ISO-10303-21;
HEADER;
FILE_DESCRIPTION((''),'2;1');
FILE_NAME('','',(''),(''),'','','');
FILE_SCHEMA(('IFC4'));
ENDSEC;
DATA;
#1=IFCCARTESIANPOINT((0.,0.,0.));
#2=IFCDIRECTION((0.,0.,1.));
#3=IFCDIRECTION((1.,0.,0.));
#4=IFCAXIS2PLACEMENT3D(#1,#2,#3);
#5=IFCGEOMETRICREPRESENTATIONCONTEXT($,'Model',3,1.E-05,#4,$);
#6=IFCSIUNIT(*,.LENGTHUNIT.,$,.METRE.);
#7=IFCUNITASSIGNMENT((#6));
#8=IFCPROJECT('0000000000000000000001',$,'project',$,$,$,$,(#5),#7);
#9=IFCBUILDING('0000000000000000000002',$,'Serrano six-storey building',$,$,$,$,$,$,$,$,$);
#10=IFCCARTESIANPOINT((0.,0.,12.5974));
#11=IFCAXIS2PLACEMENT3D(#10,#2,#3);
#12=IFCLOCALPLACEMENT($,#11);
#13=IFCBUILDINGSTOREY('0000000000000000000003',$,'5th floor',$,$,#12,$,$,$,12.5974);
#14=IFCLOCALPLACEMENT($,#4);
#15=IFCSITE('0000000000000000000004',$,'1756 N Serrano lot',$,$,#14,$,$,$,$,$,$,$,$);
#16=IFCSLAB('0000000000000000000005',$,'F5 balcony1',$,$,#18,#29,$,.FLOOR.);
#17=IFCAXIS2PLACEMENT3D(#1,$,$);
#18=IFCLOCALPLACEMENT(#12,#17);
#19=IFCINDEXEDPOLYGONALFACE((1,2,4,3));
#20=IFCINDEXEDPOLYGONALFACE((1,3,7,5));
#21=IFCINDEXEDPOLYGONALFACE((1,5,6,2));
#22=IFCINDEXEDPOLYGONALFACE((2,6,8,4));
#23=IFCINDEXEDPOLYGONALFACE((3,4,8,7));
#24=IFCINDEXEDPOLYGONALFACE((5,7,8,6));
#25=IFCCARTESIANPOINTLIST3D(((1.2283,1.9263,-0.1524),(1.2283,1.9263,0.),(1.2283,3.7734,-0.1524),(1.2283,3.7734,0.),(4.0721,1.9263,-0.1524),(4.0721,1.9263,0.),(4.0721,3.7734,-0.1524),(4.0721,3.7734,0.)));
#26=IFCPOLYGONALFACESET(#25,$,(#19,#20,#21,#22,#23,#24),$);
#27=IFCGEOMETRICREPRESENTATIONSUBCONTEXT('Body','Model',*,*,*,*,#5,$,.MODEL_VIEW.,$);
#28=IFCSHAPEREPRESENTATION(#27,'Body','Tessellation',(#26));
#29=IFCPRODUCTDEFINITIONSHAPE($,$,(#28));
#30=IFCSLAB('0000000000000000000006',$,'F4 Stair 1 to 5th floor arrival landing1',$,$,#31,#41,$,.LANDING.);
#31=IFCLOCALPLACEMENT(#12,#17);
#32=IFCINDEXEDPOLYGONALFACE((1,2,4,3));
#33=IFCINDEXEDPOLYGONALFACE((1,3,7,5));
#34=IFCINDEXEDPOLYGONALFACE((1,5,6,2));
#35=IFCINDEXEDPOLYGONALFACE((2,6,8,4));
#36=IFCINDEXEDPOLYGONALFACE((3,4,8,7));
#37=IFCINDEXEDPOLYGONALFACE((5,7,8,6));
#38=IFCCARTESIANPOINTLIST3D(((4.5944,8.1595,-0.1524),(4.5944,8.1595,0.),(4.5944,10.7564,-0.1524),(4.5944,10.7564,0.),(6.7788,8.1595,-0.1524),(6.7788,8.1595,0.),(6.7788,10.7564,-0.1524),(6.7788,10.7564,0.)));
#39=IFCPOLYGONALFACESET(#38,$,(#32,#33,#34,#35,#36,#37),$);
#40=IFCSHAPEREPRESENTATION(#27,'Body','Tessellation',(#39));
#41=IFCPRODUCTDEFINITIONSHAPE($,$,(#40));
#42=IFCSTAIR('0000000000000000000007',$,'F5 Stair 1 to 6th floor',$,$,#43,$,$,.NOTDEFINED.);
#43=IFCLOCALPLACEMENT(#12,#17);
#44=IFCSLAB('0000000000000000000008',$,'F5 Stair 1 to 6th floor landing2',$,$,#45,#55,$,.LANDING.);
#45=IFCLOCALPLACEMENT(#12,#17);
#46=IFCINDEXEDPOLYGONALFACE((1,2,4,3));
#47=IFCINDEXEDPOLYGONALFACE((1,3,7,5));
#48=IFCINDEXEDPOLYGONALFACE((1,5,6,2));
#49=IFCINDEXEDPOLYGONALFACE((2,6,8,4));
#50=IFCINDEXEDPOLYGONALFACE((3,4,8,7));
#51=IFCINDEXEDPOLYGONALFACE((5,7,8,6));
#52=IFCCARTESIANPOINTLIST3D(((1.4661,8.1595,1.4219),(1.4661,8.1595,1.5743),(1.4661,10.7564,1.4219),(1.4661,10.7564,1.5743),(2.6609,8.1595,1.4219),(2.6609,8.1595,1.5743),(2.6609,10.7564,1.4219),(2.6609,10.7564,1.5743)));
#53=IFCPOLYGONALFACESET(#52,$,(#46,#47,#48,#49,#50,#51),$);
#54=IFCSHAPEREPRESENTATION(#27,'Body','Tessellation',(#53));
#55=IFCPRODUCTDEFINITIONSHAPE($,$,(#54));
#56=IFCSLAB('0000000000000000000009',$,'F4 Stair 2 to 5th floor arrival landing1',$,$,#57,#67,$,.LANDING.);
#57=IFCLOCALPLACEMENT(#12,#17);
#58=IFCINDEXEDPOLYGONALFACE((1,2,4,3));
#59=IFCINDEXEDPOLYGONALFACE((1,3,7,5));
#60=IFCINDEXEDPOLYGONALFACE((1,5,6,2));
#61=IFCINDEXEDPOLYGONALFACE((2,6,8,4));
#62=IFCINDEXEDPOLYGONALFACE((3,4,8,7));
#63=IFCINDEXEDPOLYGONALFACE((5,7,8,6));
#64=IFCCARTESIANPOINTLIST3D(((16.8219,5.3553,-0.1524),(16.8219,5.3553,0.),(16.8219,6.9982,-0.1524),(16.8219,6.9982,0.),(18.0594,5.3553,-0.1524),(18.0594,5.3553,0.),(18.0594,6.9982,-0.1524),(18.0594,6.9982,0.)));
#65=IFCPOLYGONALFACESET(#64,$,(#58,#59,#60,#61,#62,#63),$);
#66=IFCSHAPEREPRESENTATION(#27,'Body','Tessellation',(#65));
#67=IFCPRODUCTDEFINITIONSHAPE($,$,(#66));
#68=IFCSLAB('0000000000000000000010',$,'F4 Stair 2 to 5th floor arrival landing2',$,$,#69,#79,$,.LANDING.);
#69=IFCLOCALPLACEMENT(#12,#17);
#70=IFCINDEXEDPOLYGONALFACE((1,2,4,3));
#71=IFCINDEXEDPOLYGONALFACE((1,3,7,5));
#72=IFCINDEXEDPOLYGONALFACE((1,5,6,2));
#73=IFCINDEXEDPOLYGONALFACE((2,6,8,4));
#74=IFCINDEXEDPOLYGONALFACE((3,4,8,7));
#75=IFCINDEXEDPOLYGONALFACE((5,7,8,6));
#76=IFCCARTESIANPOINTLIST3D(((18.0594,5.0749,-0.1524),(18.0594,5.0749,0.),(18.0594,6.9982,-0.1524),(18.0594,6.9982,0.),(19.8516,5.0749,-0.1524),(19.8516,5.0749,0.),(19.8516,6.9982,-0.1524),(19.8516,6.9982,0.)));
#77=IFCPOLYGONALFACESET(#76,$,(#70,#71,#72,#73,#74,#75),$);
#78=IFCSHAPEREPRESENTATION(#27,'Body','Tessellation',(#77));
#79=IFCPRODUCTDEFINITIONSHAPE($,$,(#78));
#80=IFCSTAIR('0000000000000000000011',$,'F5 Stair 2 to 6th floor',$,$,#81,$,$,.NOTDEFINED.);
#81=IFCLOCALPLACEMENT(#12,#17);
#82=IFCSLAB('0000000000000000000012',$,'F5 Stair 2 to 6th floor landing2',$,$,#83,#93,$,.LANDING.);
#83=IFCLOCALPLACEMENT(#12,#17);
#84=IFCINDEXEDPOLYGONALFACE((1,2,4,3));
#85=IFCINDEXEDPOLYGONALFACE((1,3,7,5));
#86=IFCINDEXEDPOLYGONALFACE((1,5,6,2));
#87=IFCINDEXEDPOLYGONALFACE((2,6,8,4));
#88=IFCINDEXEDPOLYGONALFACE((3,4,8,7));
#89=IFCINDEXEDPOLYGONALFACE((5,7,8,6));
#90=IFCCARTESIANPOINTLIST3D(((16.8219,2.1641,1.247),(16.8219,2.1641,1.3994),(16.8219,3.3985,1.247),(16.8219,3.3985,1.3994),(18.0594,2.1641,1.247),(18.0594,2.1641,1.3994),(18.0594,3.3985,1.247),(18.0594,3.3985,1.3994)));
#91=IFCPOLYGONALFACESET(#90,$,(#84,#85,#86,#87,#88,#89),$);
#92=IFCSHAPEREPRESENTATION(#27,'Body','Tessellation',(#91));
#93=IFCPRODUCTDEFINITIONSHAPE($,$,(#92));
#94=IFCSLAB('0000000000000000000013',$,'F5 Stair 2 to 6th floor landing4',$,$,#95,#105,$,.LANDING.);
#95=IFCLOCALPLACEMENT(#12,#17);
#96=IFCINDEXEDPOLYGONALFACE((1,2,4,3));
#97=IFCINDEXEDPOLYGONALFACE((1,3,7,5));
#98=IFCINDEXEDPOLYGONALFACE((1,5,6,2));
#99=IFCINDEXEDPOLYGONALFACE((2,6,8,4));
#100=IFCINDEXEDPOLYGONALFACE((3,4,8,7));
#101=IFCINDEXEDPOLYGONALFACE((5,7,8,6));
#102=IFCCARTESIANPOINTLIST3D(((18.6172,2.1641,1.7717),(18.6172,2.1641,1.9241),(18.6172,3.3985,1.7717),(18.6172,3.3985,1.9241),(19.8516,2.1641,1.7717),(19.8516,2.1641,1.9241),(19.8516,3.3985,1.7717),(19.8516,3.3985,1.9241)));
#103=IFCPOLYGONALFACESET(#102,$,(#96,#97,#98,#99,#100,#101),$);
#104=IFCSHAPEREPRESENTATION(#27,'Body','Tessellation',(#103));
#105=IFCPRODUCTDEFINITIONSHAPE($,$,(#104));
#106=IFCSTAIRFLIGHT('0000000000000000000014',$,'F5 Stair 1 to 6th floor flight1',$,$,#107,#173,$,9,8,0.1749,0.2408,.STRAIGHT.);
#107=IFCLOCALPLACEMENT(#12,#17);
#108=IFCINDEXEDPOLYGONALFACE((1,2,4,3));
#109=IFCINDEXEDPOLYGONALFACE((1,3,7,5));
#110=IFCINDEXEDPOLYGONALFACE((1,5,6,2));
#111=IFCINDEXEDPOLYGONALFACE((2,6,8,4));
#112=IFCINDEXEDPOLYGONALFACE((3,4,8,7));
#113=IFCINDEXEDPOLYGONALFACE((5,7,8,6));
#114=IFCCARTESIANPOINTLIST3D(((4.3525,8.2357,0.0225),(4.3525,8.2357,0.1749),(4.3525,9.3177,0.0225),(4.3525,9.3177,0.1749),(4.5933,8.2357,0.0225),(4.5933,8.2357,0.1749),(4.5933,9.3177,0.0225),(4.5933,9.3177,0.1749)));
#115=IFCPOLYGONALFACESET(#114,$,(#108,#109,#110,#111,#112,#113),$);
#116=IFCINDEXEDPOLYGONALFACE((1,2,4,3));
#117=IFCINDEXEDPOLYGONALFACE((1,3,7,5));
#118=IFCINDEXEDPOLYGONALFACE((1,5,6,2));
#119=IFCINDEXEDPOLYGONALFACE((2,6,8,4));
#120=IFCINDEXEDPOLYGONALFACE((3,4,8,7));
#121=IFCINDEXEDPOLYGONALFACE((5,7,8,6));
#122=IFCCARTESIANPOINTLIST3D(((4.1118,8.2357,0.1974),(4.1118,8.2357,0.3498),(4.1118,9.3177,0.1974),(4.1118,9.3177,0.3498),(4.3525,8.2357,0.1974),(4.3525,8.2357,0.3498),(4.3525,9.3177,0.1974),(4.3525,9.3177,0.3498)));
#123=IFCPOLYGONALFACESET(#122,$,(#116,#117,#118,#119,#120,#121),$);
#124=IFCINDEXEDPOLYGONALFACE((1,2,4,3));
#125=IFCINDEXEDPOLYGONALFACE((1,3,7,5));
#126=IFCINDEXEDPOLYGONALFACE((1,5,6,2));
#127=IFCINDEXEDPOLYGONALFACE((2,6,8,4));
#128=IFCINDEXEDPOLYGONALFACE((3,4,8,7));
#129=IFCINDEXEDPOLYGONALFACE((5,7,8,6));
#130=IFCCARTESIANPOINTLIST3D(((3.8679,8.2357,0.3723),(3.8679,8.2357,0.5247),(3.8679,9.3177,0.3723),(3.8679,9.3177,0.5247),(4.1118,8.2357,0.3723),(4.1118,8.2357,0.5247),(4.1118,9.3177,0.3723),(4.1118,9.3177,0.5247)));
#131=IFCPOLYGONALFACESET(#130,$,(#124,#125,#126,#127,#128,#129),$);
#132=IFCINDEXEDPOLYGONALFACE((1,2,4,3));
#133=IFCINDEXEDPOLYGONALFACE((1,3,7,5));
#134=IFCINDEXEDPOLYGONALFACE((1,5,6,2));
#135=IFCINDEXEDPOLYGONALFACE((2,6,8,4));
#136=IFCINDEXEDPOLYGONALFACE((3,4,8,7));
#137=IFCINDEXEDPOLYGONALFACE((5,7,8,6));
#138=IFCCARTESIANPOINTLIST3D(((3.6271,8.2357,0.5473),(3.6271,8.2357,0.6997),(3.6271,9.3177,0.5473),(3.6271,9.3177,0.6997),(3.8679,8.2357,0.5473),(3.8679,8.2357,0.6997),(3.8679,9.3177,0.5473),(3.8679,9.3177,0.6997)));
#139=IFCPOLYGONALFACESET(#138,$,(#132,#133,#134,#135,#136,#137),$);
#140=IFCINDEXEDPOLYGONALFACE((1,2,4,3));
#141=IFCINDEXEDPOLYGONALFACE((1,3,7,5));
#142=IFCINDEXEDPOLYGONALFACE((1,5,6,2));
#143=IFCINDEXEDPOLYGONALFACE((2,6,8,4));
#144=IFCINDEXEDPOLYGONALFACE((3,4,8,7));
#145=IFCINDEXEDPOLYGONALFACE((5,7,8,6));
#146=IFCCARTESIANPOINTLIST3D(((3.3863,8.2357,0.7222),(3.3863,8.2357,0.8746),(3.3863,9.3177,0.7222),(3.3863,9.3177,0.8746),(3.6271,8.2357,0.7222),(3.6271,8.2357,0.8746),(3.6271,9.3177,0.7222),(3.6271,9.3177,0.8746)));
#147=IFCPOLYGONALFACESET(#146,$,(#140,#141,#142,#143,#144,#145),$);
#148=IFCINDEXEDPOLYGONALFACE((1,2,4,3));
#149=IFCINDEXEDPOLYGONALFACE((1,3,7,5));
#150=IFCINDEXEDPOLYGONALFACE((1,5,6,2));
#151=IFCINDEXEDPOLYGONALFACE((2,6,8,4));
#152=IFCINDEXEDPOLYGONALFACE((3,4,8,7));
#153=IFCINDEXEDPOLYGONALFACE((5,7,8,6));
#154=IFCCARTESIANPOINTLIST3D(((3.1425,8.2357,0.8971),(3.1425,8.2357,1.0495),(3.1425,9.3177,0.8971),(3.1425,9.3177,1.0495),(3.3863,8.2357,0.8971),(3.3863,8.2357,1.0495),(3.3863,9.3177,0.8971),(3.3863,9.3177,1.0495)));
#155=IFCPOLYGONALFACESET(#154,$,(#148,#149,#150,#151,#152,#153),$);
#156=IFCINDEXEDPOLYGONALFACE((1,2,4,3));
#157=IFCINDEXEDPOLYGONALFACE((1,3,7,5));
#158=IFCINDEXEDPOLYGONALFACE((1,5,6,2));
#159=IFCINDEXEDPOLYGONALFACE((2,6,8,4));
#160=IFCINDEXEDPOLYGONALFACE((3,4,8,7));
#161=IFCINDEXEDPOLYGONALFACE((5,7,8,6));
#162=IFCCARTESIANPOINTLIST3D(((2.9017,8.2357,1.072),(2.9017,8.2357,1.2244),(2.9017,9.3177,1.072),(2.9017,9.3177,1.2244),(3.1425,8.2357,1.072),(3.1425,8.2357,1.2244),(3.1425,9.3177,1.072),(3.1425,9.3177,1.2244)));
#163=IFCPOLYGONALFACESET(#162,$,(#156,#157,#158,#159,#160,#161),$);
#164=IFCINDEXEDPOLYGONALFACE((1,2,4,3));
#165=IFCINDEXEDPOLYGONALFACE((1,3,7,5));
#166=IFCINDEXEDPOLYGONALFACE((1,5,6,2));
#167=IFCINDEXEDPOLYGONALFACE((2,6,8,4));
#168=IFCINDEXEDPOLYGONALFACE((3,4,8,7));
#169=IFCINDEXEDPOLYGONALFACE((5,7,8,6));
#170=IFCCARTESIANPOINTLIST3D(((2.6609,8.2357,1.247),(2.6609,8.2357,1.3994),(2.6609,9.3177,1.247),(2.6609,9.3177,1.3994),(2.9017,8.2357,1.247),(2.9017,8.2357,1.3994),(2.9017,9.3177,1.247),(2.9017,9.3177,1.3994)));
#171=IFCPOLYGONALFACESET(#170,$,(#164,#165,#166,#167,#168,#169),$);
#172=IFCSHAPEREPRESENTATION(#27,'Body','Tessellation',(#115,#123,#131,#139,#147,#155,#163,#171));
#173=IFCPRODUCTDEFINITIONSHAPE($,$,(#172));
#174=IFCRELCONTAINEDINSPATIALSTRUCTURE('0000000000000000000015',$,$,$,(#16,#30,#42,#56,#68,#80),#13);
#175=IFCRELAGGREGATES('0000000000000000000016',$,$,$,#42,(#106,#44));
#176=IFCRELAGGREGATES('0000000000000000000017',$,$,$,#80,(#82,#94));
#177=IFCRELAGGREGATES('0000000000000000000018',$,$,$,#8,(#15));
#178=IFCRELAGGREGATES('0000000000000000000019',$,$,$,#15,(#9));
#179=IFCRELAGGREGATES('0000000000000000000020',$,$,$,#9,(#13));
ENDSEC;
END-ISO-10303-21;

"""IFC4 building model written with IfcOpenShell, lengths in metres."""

from ifc_helpers import new_model, si_unit, frame, origin_with_axes, place, context, subcontext, project, spatial, polyline, outline, extrude, element, aggregate, save


model = new_model("IFC4")

# Units and contexts
model_context = context("Model", 3, precision=1e-05, world=origin_with_axes())
body_context = subcontext(model_context, "Body", "Model", "MODEL_VIEW")
ifc_project = project(units=[si_unit("LENGTHUNIT", "METRE")], contexts=[model_context])

# Site, building, storey
site_placement = place(None, origin_with_axes())
site = spatial("IfcSite", under=ifc_project, at=site_placement, Name="1756 N Serrano lot")
building = spatial("IfcBuilding", under=site, Name="Serrano six-storey building")
storey_placement = place(None, frame((0.0, 0.0, 12.5974), z_axis=(0.0, 0.0, 1.0), x_axis=(1.0, 0.0, 0.0)))
storey = spatial("IfcBuildingStorey", under=building, at=storey_placement, Name="5th floor", Elevation=12.5974)

# Slabs
slab_1_placement = place(storey_placement, frame((0.0, 0.0, -12.5974), z_axis=(0.0, 0.0, 1.0), x_axis=(1.0, 0.0, 0.0)))
element("IfcSlab", 1, at=slab_1_placement, inside=storey, Name="F5 balcony1", PredefinedType="FLOOR", context=body_context, shape_type="SweptSolid", body=[
    extrude(outline(polyline([(4.0721, 1.9263), (4.0721, 3.7734), (1.2283, 3.7734), (1.2283, 1.9263), (4.0721, 1.9263)])), frame((0.0, 0.0, 12.445)), (0.0, 0.0, 1.0), 0.1524),
])
slab_2_placement = place(storey_placement, frame((0.0, 0.0, -12.5974), z_axis=(0.0, 0.0, 1.0), x_axis=(1.0, 0.0, 0.0)))
element("IfcSlab", 2, at=slab_2_placement, inside=storey, Name="F4 Stair 1 to 5th floor arrival landing1", PredefinedType="LANDING", context=body_context, shape_type="SweptSolid", body=[
    extrude(outline(polyline([(6.7788, 8.1595), (6.7788, 10.7564), (4.5944, 10.7564), (4.5944, 8.1595), (6.7788, 8.1595)])), frame((0.0, 0.0, 12.445)), (0.0, 0.0, 1.0), 0.1524),
])

# Stair, slab
stair_1 = element("IfcStair", 3, inside=storey, Name="F5 Stair 1 to 6th floor", PredefinedType="NOTDEFINED")
slab_3_placement = place(None, origin_with_axes())
slab_3 = element("IfcSlab", 4, at=slab_3_placement, Name="F5 Stair 1 to 6th floor landing2", PredefinedType="LANDING", context=body_context, shape_type="SweptSolid", body=[
    extrude(outline(polyline([(2.6609, 8.1595), (2.6609, 10.7564), (1.4661, 10.7564), (1.4661, 8.1595), (2.6609, 8.1595)])), frame((0.0, 0.0, 14.0193)), (0.0, 0.0, 1.0), 0.1524),
])

# Slabs
slab_4_placement = place(storey_placement, frame((0.0, 0.0, -12.5974), z_axis=(0.0, 0.0, 1.0), x_axis=(1.0, 0.0, 0.0)))
element("IfcSlab", 5, at=slab_4_placement, inside=storey, Name="F4 Stair 2 to 5th floor arrival landing1", PredefinedType="LANDING", context=body_context, shape_type="SweptSolid", body=[
    extrude(outline(polyline([(18.0594, 5.3553), (18.0594, 6.9982), (16.8219, 6.9982), (16.8219, 5.3553), (18.0594, 5.3553)])), frame((0.0, 0.0, 12.445)), (0.0, 0.0, 1.0), 0.1524),
])
slab_5_placement = place(storey_placement, frame((0.0, 0.0, -12.5974), z_axis=(0.0, 0.0, 1.0), x_axis=(1.0, 0.0, 0.0)))
element("IfcSlab", 6, at=slab_5_placement, inside=storey, Name="F4 Stair 2 to 5th floor arrival landing2", PredefinedType="LANDING", context=body_context, shape_type="SweptSolid", body=[
    extrude(outline(polyline([(19.8516, 5.0749), (19.8516, 6.9982), (18.0594, 6.9982), (18.0594, 5.0749), (19.8516, 5.0749)])), frame((0.0, 0.0, 12.445)), (0.0, 0.0, 1.0), 0.1524),
])

# Stair, slabs
stair_2 = element("IfcStair", 7, inside=storey, Name="F5 Stair 2 to 6th floor", PredefinedType="NOTDEFINED")
slab_6_placement = place(None, origin_with_axes())
slab_6 = element("IfcSlab", 8, at=slab_6_placement, Name="F5 Stair 2 to 6th floor landing2", PredefinedType="LANDING", context=body_context, shape_type="SweptSolid", body=[
    extrude(outline(polyline([(18.0594, 2.1641), (18.0594, 3.3985), (16.8219, 3.3985), (16.8219, 2.1641), (18.0594, 2.1641)])), frame((0.0, 0.0, 13.8444)), (0.0, 0.0, 1.0), 0.1524),
])
slab_7_placement = place(None, origin_with_axes())
slab_7 = element("IfcSlab", 9, at=slab_7_placement, Name="F5 Stair 2 to 6th floor landing4", PredefinedType="LANDING", context=body_context, shape_type="SweptSolid", body=[
    extrude(outline(polyline([(19.8516, 2.1641), (19.8516, 3.3985), (18.6172, 3.3985), (18.6172, 2.1641), (19.8516, 2.1641)])), frame((0.0, 0.0, 14.3691)), (0.0, 0.0, 1.0), 0.1524),
])

# Stair flight
stair_flight_1_placement = place(None, origin_with_axes())
stair_flight_1 = element("IfcStairFlight", 10, at=stair_flight_1_placement, Name="F5 Stair 1 to 6th floor flight1", NumberOfRisers=9, NumberOfTreads=8, PredefinedType="STRAIGHT", RiserHeight=0.1749, TreadLength=0.2408, context=body_context, shape_type="SweptSolid", body=[
    extrude(outline(polyline([(4.5933, 8.2357), (4.5933, 9.3177), (4.3525, 9.3177), (4.3525, 8.2357), (4.5933, 8.2357)])), frame((0.0, 0.0, 12.6199)), (0.0, 0.0, 1.0), 0.1524),
    extrude(outline(polyline([(4.3525, 8.2357), (4.3525, 9.3177), (4.1118, 9.3177), (4.1118, 8.2357), (4.3525, 8.2357)])), frame((0.0, 0.0, 12.7948)), (0.0, 0.0, 1.0), 0.1524),
    extrude(outline(polyline([(4.1118, 8.2357), (4.1118, 9.3177), (3.8679, 9.3177), (3.8679, 8.2357), (4.1118, 8.2357)])), frame((0.0, 0.0, 12.9697)), (0.0, 0.0, 1.0), 0.1524),
    extrude(outline(polyline([(3.8679, 8.2357), (3.8679, 9.3177), (3.6271, 9.3177), (3.6271, 8.2357), (3.8679, 8.2357)])), frame((0.0, 0.0, 13.1447)), (0.0, 0.0, 1.0), 0.1524),
    extrude(outline(polyline([(3.6271, 8.2357), (3.6271, 9.3177), (3.3863, 9.3177), (3.3863, 8.2357), (3.6271, 8.2357)])), frame((0.0, 0.0, 13.3196)), (0.0, 0.0, 1.0), 0.1524),
    extrude(outline(polyline([(3.3863, 8.2357), (3.3863, 9.3177), (3.1425, 9.3177), (3.1425, 8.2357), (3.3863, 8.2357)])), frame((0.0, 0.0, 13.4945)), (0.0, 0.0, 1.0), 0.1524),
    extrude(outline(polyline([(3.1425, 8.2357), (3.1425, 9.3177), (2.9017, 9.3177), (2.9017, 8.2357), (3.1425, 8.2357)])), frame((0.0, 0.0, 13.6694)), (0.0, 0.0, 1.0), 0.1524),
    extrude(outline(polyline([(2.9017, 8.2357), (2.9017, 9.3177), (2.6609, 9.3177), (2.6609, 8.2357), (2.9017, 8.2357)])), frame((0.0, 0.0, 13.8444)), (0.0, 0.0, 1.0), 0.1524),
])
aggregate(stair_1, [stair_flight_1, slab_3])
aggregate(stair_2, [slab_6, slab_7])

save(model, "model.ifc")
